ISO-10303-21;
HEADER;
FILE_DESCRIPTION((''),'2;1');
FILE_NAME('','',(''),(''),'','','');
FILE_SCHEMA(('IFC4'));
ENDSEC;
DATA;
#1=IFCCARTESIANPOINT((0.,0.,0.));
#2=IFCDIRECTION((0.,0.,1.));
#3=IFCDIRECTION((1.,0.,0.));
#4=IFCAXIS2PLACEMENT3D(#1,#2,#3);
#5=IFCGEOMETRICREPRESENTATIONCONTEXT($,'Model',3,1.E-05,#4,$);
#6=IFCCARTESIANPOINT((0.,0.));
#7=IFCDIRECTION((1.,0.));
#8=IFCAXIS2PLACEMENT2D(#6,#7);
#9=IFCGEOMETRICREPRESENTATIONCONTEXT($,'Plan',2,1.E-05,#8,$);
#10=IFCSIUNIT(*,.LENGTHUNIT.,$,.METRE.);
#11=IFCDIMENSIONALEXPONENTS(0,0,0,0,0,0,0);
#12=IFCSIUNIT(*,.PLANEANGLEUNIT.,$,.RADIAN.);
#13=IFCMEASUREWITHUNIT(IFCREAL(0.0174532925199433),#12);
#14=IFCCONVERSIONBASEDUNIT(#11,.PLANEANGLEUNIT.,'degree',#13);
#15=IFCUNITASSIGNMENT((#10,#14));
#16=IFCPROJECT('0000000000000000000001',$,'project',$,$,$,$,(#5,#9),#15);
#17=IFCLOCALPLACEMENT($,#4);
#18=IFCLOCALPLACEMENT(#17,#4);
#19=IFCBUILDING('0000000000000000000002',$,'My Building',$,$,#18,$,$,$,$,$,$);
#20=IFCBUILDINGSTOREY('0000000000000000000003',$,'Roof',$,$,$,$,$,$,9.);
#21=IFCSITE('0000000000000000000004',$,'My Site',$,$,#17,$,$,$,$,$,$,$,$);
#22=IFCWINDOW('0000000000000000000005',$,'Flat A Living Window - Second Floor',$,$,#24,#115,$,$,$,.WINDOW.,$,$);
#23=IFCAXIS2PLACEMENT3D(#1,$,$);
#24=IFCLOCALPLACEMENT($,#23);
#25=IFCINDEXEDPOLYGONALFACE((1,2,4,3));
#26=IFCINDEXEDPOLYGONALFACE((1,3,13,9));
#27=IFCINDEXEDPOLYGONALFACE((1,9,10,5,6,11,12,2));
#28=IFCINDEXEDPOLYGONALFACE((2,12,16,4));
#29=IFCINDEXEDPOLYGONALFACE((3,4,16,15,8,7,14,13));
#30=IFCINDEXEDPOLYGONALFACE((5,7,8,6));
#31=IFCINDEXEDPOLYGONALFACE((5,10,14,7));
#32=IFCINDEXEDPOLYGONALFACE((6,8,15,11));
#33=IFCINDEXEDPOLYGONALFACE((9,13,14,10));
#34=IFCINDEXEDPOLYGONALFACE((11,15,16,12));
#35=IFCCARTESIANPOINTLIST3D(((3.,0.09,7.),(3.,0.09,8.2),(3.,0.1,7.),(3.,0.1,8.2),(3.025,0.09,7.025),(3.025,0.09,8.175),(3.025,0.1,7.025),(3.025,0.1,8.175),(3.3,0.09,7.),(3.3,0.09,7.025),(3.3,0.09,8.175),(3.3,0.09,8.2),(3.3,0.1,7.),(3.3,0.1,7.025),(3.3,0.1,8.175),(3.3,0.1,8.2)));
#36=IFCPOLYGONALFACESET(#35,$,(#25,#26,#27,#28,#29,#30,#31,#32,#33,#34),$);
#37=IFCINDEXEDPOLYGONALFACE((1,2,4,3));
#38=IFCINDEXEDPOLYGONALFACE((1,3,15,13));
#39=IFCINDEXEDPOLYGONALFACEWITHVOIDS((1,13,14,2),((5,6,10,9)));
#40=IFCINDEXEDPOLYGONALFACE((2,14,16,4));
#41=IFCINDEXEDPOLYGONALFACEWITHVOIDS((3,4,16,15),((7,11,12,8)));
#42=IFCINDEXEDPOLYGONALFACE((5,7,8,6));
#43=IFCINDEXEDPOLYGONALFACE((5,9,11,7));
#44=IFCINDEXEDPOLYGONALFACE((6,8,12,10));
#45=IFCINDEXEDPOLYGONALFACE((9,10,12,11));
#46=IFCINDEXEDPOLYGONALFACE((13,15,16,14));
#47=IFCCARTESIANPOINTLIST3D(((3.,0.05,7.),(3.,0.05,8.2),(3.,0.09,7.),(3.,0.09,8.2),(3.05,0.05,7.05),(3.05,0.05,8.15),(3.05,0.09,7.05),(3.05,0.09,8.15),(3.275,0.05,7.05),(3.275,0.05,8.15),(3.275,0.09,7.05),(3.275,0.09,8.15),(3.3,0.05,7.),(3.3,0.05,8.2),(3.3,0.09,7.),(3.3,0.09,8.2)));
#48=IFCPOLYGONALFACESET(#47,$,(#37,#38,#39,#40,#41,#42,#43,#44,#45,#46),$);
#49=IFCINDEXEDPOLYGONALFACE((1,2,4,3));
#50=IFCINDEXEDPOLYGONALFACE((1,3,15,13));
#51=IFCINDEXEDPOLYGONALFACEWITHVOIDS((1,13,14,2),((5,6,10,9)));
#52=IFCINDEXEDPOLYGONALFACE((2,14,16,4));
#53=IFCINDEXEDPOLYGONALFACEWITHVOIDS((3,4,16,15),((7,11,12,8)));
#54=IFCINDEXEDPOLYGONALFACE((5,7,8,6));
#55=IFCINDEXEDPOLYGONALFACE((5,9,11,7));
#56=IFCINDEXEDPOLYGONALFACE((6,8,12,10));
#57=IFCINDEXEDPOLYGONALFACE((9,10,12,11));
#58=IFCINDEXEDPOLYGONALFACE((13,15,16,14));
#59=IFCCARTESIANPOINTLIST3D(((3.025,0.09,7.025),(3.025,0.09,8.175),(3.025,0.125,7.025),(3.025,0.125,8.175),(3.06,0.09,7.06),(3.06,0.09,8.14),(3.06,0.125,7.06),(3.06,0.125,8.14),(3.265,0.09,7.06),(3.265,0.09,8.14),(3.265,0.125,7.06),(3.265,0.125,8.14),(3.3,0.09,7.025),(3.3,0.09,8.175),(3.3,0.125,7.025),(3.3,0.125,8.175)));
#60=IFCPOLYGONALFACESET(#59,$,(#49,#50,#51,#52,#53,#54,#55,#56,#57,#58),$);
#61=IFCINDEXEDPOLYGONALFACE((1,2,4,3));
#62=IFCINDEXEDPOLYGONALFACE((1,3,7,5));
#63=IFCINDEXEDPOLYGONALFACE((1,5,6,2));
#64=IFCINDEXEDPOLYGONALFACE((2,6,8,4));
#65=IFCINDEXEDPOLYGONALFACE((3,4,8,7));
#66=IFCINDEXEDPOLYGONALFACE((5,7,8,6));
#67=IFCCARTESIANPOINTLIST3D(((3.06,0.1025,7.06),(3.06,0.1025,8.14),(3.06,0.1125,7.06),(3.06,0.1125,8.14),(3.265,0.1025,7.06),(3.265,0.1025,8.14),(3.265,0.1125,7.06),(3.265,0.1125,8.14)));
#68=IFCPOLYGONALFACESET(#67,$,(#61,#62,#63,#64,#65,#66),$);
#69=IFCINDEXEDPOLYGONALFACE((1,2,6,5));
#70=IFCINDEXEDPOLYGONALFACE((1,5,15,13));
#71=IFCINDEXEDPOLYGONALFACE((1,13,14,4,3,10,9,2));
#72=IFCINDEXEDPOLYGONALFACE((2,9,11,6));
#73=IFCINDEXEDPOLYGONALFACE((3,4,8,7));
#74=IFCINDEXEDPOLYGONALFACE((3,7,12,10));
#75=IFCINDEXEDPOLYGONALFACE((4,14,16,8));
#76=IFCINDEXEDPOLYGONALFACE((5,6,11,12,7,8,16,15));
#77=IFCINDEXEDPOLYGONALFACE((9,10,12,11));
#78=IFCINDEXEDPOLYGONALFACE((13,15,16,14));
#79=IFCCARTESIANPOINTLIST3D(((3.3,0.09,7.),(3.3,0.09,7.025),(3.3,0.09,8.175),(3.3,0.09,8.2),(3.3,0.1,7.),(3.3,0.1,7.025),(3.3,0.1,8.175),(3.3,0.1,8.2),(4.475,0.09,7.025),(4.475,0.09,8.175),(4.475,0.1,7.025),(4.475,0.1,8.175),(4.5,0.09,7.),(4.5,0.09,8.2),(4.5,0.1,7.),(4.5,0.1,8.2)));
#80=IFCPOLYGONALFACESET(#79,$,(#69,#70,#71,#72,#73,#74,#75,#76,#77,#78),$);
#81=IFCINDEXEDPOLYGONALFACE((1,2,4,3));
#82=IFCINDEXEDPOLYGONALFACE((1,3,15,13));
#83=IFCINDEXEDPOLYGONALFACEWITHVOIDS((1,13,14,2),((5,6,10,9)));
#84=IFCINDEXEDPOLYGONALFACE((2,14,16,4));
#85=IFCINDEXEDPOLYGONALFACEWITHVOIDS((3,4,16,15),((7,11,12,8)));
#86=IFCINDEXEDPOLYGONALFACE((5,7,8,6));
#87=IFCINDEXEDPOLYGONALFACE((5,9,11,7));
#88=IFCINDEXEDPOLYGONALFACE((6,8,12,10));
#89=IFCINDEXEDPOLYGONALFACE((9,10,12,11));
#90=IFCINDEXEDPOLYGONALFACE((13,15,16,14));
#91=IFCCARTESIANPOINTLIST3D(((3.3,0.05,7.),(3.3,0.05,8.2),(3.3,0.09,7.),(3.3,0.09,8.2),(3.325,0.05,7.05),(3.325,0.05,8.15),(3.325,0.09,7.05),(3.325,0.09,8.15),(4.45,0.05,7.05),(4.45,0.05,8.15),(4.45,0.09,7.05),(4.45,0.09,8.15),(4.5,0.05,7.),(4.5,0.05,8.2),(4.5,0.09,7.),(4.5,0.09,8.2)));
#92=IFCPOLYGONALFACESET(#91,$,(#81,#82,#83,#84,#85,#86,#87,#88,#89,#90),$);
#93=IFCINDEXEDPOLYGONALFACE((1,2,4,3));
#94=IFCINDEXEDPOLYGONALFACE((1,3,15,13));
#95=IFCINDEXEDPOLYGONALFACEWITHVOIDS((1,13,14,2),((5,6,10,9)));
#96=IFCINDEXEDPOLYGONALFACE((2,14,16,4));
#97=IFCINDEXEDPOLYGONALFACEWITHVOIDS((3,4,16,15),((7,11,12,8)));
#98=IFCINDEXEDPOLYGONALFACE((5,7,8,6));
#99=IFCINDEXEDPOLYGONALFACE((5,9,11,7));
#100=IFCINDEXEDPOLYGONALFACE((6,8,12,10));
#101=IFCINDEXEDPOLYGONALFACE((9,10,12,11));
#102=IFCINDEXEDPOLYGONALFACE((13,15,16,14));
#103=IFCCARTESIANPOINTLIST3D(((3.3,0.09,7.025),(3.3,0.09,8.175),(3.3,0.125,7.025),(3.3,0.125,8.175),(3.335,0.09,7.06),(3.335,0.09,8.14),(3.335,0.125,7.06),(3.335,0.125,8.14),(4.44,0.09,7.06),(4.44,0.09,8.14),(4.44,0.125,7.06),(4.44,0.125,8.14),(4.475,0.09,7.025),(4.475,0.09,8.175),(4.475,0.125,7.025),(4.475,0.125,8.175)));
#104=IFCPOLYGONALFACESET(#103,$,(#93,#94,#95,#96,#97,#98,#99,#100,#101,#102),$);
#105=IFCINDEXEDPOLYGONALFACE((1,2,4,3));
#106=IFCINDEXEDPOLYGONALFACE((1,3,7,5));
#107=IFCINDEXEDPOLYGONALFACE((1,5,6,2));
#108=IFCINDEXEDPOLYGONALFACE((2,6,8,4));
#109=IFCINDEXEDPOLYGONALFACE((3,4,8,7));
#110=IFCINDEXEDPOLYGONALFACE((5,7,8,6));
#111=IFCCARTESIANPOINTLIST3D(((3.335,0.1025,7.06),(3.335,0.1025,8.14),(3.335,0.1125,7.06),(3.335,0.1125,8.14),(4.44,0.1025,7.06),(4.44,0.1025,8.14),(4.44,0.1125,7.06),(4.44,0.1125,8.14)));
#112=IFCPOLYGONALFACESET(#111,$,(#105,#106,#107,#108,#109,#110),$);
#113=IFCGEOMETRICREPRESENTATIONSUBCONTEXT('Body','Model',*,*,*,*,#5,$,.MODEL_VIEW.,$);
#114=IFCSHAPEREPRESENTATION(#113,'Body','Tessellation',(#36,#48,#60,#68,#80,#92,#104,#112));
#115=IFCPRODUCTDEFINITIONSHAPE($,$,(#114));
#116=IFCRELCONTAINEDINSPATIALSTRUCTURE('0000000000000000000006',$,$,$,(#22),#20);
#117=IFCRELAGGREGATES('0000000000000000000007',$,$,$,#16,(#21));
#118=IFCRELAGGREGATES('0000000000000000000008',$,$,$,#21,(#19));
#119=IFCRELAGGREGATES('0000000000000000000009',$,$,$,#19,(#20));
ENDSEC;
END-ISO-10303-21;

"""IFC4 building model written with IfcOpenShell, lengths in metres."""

from ifc_helpers import new_model, entity, si_unit, converted_unit, frame, origin_with_axes, origin_2d_with_axis, place, context, subcontext, project, spatial, line, indexed_curve, outline, extrude, element, save


model = new_model("IFC4")

# Units and contexts
model_context = context("Model", 3, precision=1e-05, world=origin_with_axes())
plan_context = context("Plan", 2, precision=1e-05, world=origin_2d_with_axis())
body_context = subcontext(model_context, "Body", "Model", "MODEL_VIEW")
ifc_project = project(units=[si_unit("LENGTHUNIT", "METRE"), converted_unit("PLANEANGLEUNIT", "degree", entity("IfcReal", 0.0174532925199433), si_unit("PLANEANGLEUNIT", "RADIAN"), dimensions=[0, 0, 0, 0, 0, 0, 0])], contexts=[model_context, plan_context])

# Site, building, storey
site_placement = place(None, origin_with_axes())
site = spatial("IfcSite", under=ifc_project, at=site_placement, Name="My Site")
building_placement = place(site_placement, origin_with_axes())
building = spatial("IfcBuilding", under=site, at=building_placement, Name="My Building")
storey = spatial("IfcBuildingStorey", under=building, Name="Roof", Elevation=9.0)

# Window
window_1_placement = place(None, frame((3.0, 0.0, 7.0), z_axis=(0.0, 0.0, 1.0), x_axis=(1.0, 0.0, 0.0)))
element("IfcWindow", 1, at=window_1_placement, inside=storey, Name="Flat A Living Window - Second Floor", PredefinedType="WINDOW", context=body_context, shape_type="SweptSolid", body=[
    extrude(outline(indexed_curve([(0.3, 0.0), (0.0, 0.0), (0.0, 1.2), (0.3, 1.2), (0.3, 1.175), (0.025, 1.175), (0.025, 0.025), (0.3, 0.025)], segments=[line(1, 2, 3, 4, 5, 6, 7, 8, 1)])), frame((0.0, 0.09, 0.0), z_axis=(0.0, -1.0, 0.0), x_axis=(1.0, 0.0, 0.0)), (0.0, 0.0, -1.0), 0.01),
    extrude(outline(indexed_curve([(0.0, 0.0), (0.3, 0.0), (0.3, 1.2), (0.0, 1.2)], segments=[line(1, 2, 3, 4, 1)]), holes=[indexed_curve([(0.05, 0.05), (0.275, 0.05), (0.275, 1.15), (0.05, 1.15)], segments=[line(1, 2, 3, 4, 1)])]), frame((0.0, 0.05, 0.0), z_axis=(0.0, -1.0, 0.0), x_axis=(1.0, 0.0, 0.0)), (0.0, 0.0, -1.0), 0.04),
    extrude(outline(indexed_curve([(0.0, 0.0), (0.275, 0.0), (0.275, 1.15), (0.0, 1.15)], segments=[line(1, 2, 3, 4, 1)]), holes=[indexed_curve([(0.035, 0.035), (0.24, 0.035), (0.24, 1.115), (0.035, 1.115)], segments=[line(1, 2, 3, 4, 1)])]), frame((0.025, 0.09, 0.025), z_axis=(0.0, -1.0, 0.0), x_axis=(1.0, 0.0, 0.0)), (0.0, 0.0, -1.0), 0.035),
    extrude(outline(indexed_curve([(0.035, 0.035), (0.24, 0.035), (0.24, 1.115), (0.035, 1.115)], segments=[line(1, 2, 3, 4, 1)])), frame((0.025, 0.1025, 0.025), z_axis=(0.0, -1.0, 0.0), x_axis=(1.0, 0.0, 0.0)), (0.0, 0.0, -1.0), 0.01),
    extrude(outline(indexed_curve([(0.0, 1.2), (1.2, 1.2), (1.2, 0.0), (0.0, 0.0), (0.0, 0.025), (1.175, 0.025), (1.175, 1.175), (0.0, 1.175)], segments=[line(1, 2, 3, 4, 5, 6, 7, 8, 1)])), frame((0.3, 0.09, 0.0), z_axis=(0.0, -1.0, 0.0), x_axis=(1.0, 0.0, 0.0)), (0.0, 0.0, -1.0), 0.01),
    extrude(outline(indexed_curve([(0.0, 0.0), (1.2, 0.0), (1.2, 1.2), (0.0, 1.2)], segments=[line(1, 2, 3, 4, 1)]), holes=[indexed_curve([(0.025, 0.05), (1.15, 0.05), (1.15, 1.15), (0.025, 1.15)], segments=[line(1, 2, 3, 4, 1)])]), frame((0.3, 0.05, 0.0), z_axis=(0.0, -1.0, 0.0), x_axis=(1.0, 0.0, 0.0)), (0.0, 0.0, -1.0), 0.04),
    extrude(outline(indexed_curve([(0.0, 0.0), (1.175, 0.0), (1.175, 1.15), (0.0, 1.15)], segments=[line(1, 2, 3, 4, 1)]), holes=[indexed_curve([(0.035, 0.035), (1.14, 0.035), (1.14, 1.115), (0.035, 1.115)], segments=[line(1, 2, 3, 4, 1)])]), frame((0.3, 0.09, 0.025), z_axis=(0.0, -1.0, 0.0), x_axis=(1.0, 0.0, 0.0)), (0.0, 0.0, -1.0), 0.035),
    extrude(outline(indexed_curve([(0.035, 0.035), (1.14, 0.035), (1.14, 1.115), (0.035, 1.115)], segments=[line(1, 2, 3, 4, 1)])), frame((0.3, 0.1025, 0.025), z_axis=(0.0, -1.0, 0.0), x_axis=(1.0, 0.0, 0.0)), (0.0, 0.0, -1.0), 0.01),
])

save(model, "model.ifc")
